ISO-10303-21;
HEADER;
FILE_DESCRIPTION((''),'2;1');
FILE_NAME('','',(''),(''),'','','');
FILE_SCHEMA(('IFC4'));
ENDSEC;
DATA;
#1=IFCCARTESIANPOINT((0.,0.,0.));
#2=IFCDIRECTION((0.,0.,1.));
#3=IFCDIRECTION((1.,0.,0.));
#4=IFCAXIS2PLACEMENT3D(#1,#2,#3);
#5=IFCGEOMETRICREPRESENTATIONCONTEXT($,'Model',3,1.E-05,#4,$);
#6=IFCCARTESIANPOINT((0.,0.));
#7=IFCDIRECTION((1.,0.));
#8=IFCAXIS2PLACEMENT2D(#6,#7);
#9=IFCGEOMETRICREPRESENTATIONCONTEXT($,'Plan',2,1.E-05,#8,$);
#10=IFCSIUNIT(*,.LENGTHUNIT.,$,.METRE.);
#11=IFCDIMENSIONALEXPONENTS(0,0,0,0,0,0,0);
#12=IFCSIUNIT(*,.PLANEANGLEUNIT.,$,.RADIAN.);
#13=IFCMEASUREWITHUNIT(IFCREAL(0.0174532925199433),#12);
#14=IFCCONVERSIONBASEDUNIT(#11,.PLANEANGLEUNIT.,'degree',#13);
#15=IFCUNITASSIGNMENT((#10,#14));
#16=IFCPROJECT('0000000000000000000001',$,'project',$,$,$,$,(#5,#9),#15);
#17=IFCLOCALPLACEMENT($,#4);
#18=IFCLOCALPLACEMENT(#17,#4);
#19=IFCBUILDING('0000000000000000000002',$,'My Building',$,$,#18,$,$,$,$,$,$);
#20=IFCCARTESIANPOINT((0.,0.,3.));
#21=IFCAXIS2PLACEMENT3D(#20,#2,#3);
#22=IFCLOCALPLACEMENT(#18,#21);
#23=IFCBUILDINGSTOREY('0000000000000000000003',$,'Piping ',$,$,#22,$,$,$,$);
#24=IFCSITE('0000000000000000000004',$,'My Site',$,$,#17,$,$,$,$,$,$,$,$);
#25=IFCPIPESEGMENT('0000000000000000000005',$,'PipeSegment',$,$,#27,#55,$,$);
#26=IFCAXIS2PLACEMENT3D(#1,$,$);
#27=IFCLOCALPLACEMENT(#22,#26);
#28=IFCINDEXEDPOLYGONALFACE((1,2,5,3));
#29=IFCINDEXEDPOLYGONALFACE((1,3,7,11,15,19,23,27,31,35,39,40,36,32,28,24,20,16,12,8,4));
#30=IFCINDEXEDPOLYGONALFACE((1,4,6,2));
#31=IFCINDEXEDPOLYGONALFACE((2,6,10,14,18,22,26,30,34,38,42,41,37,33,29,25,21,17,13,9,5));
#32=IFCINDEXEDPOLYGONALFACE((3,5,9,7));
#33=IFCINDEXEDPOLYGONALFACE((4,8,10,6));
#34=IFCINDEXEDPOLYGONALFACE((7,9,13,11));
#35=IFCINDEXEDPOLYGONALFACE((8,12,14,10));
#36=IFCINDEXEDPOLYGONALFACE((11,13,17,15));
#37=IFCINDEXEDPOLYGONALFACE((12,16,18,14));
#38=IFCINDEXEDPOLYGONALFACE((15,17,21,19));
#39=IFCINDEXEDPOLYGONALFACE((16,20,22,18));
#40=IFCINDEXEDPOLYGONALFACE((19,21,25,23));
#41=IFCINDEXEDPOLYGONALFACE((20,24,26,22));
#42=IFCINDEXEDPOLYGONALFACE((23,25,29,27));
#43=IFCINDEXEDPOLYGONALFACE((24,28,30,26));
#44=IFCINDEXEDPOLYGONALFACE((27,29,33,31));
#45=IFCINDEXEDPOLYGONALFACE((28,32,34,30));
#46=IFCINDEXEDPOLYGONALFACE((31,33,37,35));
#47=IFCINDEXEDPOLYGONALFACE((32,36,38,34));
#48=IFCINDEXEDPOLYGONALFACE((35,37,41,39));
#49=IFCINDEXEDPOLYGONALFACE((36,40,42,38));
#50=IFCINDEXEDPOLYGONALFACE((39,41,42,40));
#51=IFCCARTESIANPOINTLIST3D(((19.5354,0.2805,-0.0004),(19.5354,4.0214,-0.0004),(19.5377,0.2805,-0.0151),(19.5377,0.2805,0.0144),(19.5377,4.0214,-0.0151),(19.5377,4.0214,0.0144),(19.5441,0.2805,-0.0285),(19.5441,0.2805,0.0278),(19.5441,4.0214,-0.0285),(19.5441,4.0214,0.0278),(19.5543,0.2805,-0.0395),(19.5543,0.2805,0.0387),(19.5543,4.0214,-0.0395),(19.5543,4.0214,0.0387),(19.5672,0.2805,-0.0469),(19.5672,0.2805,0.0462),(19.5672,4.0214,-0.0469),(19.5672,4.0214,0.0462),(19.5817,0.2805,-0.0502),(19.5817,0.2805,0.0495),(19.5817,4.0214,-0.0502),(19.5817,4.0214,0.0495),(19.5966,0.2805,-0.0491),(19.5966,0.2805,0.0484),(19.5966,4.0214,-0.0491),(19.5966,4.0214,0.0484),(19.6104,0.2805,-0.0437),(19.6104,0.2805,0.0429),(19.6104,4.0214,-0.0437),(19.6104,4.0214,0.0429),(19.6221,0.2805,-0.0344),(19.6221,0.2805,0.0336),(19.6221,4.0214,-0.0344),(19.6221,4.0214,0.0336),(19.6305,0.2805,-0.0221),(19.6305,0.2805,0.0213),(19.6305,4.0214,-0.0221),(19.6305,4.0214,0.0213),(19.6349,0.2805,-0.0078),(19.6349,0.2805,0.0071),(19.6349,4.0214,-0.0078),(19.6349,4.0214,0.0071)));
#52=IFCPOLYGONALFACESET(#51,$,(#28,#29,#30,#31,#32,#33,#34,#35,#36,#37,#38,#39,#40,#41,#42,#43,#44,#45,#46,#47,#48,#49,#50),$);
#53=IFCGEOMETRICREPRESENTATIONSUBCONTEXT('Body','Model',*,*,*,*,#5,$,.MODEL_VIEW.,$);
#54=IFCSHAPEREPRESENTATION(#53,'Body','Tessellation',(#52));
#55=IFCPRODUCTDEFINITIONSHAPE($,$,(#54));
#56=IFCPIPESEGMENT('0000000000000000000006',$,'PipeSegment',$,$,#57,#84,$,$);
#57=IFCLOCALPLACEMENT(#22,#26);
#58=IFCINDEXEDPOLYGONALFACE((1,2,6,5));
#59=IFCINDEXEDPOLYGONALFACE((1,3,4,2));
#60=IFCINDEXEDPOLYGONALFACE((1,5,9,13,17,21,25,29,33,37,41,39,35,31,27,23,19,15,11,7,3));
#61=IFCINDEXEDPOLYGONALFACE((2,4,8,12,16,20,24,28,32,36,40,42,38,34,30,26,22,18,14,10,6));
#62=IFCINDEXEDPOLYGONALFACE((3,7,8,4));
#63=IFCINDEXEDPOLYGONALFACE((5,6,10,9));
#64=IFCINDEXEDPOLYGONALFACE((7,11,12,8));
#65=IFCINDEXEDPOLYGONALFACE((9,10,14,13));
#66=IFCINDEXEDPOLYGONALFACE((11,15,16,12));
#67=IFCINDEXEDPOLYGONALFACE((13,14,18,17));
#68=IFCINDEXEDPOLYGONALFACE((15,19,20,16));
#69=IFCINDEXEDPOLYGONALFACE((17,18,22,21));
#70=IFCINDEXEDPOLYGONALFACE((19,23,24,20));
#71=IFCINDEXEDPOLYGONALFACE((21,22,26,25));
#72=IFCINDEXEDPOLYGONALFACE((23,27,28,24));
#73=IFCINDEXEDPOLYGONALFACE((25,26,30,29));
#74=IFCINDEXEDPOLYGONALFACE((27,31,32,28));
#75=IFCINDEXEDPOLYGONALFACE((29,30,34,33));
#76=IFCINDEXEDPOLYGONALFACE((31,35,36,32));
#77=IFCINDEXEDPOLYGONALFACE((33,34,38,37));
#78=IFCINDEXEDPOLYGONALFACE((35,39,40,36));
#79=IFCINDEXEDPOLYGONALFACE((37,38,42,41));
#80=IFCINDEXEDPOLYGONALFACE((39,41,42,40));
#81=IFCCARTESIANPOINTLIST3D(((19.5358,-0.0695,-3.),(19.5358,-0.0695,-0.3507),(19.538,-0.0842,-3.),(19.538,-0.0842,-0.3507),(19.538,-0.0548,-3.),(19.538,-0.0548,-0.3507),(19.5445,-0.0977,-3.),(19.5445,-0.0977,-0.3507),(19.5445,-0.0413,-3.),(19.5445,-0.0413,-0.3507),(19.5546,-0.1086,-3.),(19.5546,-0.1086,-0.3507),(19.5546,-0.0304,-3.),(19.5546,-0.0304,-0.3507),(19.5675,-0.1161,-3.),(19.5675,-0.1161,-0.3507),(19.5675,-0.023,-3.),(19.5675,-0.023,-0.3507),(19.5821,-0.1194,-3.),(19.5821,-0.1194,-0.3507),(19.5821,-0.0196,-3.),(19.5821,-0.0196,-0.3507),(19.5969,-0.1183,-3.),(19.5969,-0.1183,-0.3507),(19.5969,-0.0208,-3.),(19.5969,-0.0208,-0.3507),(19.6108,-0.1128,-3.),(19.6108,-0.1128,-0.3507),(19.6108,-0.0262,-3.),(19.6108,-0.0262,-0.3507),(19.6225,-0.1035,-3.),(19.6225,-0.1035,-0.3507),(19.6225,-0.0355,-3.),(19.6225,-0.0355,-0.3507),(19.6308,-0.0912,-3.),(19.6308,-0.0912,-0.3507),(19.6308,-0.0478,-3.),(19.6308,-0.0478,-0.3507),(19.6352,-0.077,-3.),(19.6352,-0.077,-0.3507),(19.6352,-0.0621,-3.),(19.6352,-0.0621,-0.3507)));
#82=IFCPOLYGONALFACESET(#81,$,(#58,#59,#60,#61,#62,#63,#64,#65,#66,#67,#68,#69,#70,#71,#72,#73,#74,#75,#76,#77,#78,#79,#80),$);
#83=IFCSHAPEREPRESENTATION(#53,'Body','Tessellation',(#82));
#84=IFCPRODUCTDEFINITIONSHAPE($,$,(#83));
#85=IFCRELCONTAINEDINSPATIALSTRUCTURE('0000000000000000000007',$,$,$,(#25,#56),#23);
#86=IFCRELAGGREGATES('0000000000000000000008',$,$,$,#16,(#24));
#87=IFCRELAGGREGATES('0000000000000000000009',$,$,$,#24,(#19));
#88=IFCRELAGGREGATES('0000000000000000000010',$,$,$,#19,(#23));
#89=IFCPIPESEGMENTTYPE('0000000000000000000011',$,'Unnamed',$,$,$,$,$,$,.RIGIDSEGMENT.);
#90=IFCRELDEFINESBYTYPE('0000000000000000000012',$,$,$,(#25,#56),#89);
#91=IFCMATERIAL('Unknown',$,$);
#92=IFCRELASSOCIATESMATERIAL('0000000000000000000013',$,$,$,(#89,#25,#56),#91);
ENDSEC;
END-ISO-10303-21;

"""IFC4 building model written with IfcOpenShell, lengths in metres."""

from ifc_helpers import new_model, entity, si_unit, converted_unit, frame, origin_with_axes, origin_2d_with_axis, place, context, subcontext, project, spatial, circle, extrude, material, material_profile, profile_set, profile_usage, type_object, element, save


model = new_model("IFC4")

# Units and contexts
model_context = context("Model", 3, precision=1e-05, world=origin_with_axes())
plan_context = context("Plan", 2, precision=1e-05, world=origin_2d_with_axis())
body_context = subcontext(model_context, "Body", "Model", "MODEL_VIEW")
ifc_project = project(units=[si_unit("LENGTHUNIT", "METRE"), converted_unit("PLANEANGLEUNIT", "degree", entity("IfcReal", 0.0174532925199433), si_unit("PLANEANGLEUNIT", "RADIAN"), dimensions=[0, 0, 0, 0, 0, 0, 0])], contexts=[model_context, plan_context])

# Site, building, storey
site_placement = place(None, origin_with_axes())
site = spatial("IfcSite", under=ifc_project, at=site_placement, Name="My Site")
building_placement = place(site_placement, origin_with_axes())
building = spatial("IfcBuilding", under=site, at=building_placement, Name="My Building")
storey_placement = place(building_placement, frame((0.0, 0.0, 3.0), z_axis=(0.0, 0.0, 1.0), x_axis=(1.0, 0.0, 0.0)))
storey = spatial("IfcBuildingStorey", under=building, at=storey_placement, Name="Piping ")

# Pipe segments
ifc_material = material(Name="Unknown")
ifc_material_profile = material_profile(ifc_material, circle(Radius=0.05))
ifc_profile_set = profile_set([ifc_material_profile])
pipe_segment_type = type_object("IfcPipeSegmentType", Name="Unnamed", PredefinedType="RIGIDSEGMENT", material=ifc_profile_set)
ifc_profile_usage_1 = profile_usage(ifc_profile_set, cardinal=5)
pipe_segment_1_placement = place(storey_placement, frame((19.5854, 0.2805, -0.0004), z_axis=(0.0, 1.0, 0.0), x_axis=(-1.0, 0.0, 0.0)))
element("IfcPipeSegment", 1, at=pipe_segment_1_placement, inside=storey, type_object=pipe_segment_type, material=ifc_profile_usage_1, Name="PipeSegment", context=body_context, shape_type="SweptSolid", body=[
    extrude(circle(Radius=0.05), origin_with_axes(), (0.0, 0.0, 1.0), 3.7409),
])
ifc_profile_usage_2 = profile_usage(ifc_profile_set, cardinal=5)
pipe_segment_2_placement = place(storey_placement, frame((19.5858, -0.0695, -0.3507), z_axis=(0.0, 0.0, -1.0), x_axis=(-1.0, 0.0, 0.0)))
element("IfcPipeSegment", 2, at=pipe_segment_2_placement, inside=storey, type_object=pipe_segment_type, material=ifc_profile_usage_2, Name="PipeSegment", context=body_context, shape_type="SweptSolid", body=[
    extrude(circle(Radius=0.05), origin_with_axes(), (0.0, 0.0, 1.0), 2.6493),
])

save(model, "model.ifc")
